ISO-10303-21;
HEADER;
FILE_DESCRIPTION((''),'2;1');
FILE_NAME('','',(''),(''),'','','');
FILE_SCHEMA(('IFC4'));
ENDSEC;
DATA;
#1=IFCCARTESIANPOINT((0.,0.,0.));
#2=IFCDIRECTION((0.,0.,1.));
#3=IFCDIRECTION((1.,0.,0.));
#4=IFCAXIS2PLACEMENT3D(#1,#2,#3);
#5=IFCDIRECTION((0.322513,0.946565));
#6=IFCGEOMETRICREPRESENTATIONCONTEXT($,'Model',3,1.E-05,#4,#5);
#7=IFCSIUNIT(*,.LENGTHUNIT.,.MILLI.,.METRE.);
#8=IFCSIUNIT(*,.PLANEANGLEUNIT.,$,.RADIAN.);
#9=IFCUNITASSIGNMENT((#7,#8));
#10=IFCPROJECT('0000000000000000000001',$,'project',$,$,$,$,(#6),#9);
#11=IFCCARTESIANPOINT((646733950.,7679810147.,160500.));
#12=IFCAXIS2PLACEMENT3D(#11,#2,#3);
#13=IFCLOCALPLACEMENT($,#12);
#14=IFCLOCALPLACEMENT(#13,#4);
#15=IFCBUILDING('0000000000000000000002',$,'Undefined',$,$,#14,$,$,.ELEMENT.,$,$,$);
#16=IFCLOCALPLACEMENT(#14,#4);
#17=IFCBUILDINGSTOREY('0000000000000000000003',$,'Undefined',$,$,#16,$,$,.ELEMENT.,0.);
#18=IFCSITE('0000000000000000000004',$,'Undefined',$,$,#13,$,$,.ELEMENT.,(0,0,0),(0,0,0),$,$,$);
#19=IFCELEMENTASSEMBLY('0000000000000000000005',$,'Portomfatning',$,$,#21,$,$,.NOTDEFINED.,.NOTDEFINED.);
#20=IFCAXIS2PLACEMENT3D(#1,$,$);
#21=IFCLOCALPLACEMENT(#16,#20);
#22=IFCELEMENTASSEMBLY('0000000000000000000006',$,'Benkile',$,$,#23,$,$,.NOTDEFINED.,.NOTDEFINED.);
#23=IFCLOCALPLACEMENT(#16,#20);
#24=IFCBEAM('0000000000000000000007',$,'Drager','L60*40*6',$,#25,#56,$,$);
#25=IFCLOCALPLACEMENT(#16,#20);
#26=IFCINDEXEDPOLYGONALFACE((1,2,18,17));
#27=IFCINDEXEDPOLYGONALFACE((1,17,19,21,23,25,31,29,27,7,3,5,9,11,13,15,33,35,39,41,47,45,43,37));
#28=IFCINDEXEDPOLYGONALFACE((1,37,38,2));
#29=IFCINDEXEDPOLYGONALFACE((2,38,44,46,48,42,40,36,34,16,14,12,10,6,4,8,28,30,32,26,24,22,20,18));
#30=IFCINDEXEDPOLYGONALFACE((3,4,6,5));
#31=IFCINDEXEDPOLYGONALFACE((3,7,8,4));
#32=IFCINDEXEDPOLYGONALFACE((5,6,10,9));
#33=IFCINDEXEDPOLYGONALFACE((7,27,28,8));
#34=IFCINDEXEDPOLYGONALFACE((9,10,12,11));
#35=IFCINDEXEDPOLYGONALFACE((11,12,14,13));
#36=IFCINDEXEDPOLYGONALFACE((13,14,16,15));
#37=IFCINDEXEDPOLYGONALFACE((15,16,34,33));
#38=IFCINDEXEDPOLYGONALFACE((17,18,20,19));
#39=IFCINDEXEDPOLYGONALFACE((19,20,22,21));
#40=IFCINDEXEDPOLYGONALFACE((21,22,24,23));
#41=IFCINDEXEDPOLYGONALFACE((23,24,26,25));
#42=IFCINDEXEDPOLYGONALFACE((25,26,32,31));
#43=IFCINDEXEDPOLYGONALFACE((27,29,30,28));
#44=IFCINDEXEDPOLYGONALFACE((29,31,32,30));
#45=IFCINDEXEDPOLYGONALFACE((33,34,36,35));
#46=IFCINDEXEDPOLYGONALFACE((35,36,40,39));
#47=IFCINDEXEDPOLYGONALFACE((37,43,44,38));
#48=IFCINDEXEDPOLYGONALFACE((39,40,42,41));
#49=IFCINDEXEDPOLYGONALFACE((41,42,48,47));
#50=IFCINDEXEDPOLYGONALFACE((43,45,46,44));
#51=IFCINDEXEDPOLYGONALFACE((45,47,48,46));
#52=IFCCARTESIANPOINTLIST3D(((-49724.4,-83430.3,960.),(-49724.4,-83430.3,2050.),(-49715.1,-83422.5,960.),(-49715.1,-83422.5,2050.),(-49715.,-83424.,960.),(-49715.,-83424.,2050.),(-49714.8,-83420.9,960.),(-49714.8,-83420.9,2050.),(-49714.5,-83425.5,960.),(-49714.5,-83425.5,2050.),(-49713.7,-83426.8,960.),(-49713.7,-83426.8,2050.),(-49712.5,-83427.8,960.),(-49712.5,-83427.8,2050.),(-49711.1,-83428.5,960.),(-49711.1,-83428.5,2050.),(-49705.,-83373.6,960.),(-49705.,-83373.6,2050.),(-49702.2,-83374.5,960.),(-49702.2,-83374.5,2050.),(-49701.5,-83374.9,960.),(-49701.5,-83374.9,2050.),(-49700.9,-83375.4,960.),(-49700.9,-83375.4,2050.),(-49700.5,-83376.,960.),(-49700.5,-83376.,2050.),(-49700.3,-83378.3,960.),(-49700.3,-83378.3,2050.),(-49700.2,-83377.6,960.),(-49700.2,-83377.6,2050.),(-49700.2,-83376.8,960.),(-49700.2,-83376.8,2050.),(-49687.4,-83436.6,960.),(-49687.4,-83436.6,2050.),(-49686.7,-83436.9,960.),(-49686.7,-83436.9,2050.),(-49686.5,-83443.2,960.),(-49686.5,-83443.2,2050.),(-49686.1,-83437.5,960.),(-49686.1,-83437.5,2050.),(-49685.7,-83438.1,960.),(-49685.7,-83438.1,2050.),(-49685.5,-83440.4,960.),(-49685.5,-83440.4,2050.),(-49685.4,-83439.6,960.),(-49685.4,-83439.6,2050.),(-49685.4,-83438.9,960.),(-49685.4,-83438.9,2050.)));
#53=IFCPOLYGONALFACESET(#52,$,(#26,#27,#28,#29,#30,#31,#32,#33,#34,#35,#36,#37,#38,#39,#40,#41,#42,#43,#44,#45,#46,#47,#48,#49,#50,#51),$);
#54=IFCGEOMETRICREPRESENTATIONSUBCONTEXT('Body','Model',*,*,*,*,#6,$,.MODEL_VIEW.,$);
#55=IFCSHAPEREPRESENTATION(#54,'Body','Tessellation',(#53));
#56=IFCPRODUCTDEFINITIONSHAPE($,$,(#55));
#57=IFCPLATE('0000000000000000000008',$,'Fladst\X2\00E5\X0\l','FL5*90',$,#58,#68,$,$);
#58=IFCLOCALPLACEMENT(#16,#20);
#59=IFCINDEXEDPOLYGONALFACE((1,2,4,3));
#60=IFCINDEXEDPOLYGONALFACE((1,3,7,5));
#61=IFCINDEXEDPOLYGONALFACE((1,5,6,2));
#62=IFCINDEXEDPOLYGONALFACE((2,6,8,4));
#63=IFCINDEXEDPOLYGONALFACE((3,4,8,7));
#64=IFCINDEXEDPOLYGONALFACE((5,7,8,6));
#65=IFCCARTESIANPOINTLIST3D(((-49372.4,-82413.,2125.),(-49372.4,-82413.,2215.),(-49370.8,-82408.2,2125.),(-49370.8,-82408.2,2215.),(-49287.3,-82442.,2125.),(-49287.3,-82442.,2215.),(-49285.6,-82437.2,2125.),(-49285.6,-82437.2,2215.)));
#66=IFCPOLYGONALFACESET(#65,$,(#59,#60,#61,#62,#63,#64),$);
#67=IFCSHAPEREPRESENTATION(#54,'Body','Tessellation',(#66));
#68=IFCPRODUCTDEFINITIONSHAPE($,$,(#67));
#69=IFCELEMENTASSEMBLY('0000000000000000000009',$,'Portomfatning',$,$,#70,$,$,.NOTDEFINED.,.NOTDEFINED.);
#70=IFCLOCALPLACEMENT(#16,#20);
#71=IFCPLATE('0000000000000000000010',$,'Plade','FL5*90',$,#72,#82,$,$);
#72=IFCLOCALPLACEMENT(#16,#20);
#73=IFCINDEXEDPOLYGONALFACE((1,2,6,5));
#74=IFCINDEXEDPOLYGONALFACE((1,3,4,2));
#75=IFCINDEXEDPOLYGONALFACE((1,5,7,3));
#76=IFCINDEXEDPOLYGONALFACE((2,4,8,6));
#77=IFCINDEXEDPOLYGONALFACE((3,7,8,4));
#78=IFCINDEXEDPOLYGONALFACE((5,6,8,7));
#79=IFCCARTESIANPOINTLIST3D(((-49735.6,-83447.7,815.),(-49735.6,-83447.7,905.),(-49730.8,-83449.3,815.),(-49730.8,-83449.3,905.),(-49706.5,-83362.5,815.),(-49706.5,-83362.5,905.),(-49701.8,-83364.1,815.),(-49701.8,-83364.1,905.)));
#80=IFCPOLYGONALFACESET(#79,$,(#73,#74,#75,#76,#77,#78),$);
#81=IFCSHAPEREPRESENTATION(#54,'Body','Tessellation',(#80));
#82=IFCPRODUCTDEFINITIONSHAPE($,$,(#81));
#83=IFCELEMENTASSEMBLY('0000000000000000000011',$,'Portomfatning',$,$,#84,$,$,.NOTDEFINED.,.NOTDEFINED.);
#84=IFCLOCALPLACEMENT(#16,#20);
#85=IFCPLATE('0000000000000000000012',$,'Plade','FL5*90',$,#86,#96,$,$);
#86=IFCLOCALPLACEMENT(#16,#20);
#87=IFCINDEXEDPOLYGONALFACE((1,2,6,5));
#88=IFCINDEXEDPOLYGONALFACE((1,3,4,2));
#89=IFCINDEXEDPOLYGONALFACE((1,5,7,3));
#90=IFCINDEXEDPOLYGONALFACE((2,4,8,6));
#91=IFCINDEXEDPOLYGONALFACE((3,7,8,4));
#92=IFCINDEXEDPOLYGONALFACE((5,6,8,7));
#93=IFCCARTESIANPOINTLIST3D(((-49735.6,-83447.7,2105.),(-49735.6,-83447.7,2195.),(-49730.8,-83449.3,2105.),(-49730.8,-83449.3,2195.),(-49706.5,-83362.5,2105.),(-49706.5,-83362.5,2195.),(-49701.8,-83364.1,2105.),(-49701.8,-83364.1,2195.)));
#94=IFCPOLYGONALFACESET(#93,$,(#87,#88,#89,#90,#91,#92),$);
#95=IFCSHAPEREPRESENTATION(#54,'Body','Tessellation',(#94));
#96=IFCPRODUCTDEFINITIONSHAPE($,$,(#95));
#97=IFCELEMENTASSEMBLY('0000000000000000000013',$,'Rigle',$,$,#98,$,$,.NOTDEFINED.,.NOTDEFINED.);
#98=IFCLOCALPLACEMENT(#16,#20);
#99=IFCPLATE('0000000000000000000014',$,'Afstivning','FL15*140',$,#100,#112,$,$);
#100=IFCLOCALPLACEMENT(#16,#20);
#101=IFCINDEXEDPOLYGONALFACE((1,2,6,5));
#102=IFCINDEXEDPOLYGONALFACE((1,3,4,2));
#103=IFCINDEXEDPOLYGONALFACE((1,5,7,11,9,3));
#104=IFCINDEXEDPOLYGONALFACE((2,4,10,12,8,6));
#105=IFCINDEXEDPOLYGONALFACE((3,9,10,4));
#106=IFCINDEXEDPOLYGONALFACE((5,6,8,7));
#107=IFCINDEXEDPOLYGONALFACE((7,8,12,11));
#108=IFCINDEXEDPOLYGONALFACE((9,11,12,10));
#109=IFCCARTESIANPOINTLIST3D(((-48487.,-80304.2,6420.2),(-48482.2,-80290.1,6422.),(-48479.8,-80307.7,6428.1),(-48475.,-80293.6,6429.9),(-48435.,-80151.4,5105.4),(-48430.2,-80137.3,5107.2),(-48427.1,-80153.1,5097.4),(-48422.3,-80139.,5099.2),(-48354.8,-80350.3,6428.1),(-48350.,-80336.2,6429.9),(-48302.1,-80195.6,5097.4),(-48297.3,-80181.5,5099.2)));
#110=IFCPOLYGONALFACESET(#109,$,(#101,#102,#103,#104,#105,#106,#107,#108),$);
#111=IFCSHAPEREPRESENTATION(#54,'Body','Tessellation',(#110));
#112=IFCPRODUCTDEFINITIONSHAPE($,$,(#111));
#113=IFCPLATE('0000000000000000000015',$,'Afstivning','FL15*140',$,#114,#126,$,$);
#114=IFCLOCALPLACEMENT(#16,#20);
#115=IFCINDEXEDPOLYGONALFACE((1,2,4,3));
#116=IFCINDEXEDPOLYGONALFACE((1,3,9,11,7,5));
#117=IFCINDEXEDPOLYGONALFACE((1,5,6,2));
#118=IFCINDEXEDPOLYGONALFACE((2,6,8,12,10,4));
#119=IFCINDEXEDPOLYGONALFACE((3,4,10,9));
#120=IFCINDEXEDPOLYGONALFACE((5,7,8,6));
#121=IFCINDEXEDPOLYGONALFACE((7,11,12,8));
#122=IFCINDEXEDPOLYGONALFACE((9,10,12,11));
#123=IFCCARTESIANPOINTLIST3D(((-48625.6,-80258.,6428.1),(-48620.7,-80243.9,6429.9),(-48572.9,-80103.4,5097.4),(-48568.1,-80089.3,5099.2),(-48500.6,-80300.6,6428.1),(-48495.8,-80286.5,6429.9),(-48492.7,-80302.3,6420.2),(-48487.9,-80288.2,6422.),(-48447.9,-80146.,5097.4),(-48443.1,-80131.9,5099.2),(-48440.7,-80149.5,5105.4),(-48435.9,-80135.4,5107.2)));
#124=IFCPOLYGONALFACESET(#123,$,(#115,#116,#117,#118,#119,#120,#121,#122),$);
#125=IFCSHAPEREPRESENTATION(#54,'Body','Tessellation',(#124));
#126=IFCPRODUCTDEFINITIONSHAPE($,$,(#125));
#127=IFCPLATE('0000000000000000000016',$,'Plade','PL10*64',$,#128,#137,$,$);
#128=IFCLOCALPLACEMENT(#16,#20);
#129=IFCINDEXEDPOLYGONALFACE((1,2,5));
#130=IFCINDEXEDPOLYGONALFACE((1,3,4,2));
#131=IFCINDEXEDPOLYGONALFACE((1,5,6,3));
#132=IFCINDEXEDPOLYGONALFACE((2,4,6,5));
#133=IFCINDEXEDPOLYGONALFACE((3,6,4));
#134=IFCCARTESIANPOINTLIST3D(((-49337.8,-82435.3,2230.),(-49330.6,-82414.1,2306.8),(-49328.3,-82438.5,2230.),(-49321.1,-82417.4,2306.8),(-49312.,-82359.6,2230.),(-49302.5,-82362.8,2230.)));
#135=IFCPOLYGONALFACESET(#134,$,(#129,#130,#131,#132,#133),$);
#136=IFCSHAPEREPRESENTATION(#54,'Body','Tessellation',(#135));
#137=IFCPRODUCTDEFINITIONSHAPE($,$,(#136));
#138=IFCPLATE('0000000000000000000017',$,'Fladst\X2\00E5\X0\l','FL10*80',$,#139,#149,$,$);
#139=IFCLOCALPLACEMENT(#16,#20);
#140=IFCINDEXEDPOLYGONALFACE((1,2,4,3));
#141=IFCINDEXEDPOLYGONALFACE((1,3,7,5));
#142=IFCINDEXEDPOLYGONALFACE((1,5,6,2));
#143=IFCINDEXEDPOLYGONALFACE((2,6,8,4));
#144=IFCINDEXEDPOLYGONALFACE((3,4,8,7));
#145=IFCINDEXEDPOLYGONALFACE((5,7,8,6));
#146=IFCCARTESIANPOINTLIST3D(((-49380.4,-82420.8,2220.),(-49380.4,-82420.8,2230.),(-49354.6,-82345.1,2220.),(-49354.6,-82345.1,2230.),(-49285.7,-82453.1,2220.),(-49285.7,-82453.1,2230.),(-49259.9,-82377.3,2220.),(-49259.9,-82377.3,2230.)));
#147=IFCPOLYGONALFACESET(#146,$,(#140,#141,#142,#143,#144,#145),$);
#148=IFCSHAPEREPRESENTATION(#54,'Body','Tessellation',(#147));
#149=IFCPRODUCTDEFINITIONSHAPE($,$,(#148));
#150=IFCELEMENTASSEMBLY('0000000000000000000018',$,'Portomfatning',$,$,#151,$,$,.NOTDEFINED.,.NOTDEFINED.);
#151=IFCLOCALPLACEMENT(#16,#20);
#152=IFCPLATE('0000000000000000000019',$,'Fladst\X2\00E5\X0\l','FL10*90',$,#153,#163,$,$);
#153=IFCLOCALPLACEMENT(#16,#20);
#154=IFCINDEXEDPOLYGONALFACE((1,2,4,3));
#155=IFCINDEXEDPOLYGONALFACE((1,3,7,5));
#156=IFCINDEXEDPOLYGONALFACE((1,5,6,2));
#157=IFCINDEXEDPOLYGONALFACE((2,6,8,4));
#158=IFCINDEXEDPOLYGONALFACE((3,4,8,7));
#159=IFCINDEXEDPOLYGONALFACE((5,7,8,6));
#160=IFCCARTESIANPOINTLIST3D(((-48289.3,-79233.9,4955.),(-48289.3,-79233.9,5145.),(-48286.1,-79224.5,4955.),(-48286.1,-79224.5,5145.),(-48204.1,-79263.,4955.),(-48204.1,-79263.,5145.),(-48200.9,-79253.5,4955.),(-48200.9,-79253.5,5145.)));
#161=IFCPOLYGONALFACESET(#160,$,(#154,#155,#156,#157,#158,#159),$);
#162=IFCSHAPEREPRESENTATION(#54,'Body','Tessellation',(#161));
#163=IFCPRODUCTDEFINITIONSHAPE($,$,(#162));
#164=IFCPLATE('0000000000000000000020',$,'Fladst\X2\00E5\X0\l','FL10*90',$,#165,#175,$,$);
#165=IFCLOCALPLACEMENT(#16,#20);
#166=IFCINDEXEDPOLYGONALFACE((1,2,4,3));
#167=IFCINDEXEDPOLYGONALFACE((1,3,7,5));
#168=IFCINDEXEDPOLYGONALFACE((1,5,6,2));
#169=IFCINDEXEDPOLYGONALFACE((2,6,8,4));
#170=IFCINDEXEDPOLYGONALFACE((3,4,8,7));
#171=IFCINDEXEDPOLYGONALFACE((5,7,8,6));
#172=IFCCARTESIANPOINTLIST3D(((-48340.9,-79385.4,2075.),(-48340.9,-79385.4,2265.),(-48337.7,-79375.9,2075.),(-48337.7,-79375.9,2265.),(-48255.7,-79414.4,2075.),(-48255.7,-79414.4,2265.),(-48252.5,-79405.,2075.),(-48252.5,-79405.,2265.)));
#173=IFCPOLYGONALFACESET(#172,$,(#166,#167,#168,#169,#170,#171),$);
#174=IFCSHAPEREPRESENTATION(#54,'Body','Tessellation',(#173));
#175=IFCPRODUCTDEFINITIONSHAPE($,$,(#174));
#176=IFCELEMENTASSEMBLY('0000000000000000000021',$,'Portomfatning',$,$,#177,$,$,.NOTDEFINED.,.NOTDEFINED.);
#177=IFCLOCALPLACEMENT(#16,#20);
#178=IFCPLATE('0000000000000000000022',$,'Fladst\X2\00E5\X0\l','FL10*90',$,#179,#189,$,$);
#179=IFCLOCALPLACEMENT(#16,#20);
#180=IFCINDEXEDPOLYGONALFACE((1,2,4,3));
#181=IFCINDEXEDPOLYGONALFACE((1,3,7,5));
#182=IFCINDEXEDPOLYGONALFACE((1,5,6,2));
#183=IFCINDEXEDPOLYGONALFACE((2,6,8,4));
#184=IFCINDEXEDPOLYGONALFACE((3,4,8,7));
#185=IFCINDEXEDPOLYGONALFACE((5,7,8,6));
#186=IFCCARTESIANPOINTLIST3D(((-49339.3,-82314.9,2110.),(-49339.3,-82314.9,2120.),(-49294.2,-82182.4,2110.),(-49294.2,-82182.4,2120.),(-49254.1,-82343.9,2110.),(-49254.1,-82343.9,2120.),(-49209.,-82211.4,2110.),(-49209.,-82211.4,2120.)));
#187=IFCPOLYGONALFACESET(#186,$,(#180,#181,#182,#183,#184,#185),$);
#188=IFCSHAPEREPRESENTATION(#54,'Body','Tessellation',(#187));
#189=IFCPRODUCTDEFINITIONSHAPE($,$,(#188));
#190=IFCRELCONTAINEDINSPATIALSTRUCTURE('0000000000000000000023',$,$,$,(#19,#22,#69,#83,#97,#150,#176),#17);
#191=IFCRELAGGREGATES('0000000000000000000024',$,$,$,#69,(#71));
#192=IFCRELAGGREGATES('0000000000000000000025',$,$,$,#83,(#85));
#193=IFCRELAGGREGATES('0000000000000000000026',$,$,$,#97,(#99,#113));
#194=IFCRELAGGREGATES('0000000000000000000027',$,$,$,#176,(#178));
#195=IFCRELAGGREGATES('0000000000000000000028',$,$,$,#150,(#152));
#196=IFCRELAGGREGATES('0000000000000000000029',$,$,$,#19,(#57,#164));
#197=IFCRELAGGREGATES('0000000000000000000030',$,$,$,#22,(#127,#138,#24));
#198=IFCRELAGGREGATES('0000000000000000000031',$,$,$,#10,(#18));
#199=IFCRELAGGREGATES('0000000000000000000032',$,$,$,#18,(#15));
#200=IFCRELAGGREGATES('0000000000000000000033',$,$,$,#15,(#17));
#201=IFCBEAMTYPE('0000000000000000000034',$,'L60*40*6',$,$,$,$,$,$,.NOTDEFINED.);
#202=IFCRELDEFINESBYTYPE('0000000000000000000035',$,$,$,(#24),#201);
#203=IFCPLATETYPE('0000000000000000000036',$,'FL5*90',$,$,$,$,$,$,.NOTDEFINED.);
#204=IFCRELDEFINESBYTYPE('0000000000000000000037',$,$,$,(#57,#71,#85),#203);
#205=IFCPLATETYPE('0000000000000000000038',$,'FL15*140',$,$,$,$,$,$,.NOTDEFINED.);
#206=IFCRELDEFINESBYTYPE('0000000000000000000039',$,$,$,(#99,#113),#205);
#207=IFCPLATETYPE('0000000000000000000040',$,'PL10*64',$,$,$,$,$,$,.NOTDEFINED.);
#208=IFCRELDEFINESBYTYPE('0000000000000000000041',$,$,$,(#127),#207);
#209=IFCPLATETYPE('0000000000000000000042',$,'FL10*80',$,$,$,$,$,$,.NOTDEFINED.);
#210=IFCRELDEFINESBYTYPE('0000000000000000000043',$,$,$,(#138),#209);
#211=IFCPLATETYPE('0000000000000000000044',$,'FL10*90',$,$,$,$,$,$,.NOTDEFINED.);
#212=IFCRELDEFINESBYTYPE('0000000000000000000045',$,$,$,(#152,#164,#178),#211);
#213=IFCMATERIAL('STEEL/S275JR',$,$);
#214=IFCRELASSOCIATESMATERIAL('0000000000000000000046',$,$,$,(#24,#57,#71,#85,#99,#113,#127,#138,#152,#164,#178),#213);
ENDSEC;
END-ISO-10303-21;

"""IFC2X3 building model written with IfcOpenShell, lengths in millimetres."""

from ifc_helpers import new_model, si_unit, direction, frame, origin_with_axes, origin_2d_with_axis, place, context, subcontext, project, spatial, polyline, l_section, outline, extrude, material, type_object, element, aggregate, save


model = new_model("IFC2X3")

# Units and contexts
model_context = context("Model", 3, precision=1e-05, world=origin_with_axes(), true_north=direction((0.322513, 0.946565)))
body_context = subcontext(model_context, "Body", "Model", "MODEL_VIEW")
ifc_project = project(units=[si_unit("LENGTHUNIT", "METRE", prefix="MILLI"), si_unit("PLANEANGLEUNIT", "RADIAN")], contexts=[model_context])

# Site, building, storey
site_placement = place(None, frame((646733950.0, 7679810147.0, 160500.0), z_axis=(0.0, 0.0, 1.0), x_axis=(1.0, 0.0, 0.0)))
site = spatial("IfcSite", under=ifc_project, at=site_placement, Name="Undefined", CompositionType="ELEMENT", RefLatitude=(0, 0, 0), RefLongitude=(0, 0, 0))
building_placement = place(site_placement, origin_with_axes())
building = spatial("IfcBuilding", under=site, at=building_placement, Name="Undefined", CompositionType="ELEMENT")
storey_placement = place(building_placement, origin_with_axes())
storey = spatial("IfcBuildingStorey", under=building, at=storey_placement, Name="Undefined", CompositionType="ELEMENT", Elevation=0.0)

# Element assemblies, beam
assembly_1_placement = place(storey_placement, origin_with_axes())
assembly_1 = element("IfcElementAssembly", 1, at=assembly_1_placement, inside=storey, Name="Portomfatning", AssemblyPlace="NOTDEFINED", PredefinedType="NOTDEFINED")
assembly_2_placement = place(storey_placement, origin_with_axes())
assembly_2 = element("IfcElementAssembly", 2, at=assembly_2_placement, inside=storey, Name="Benkile", AssemblyPlace="NOTDEFINED", PredefinedType="NOTDEFINED")
ifc_material_1 = material(Name="STEEL/S275JR")
beam_type_1 = type_object("IfcBeamType", Name="L60*40*6", PredefinedType="NOTDEFINED")
beam_1_placement = place(assembly_2_placement, frame((-49695.8, -83408.4, 2050.0), z_axis=(0.322513, 0.946565, 0.0), x_axis=(0.0, 0.0, -1.0)))
beam_1 = element("IfcBeam", 3, at=beam_1_placement, type_object=beam_type_1, material=ifc_material_1, Name="Drager", Description="L60*40*6", context=body_context, shape_type="SweptSolid", body=[
    extrude(l_section(Depth=60.0, Width=40.0, Thickness=6.0, FilletRadius=6.0, EdgeRadius=3.0, at=origin_2d_with_axis()), frame((1090.0, 0.0, 0.0), z_axis=(-1.0, 0.0, 0.0), x_axis=(0.0, -1.0, 0.0)), (0.0, 0.0, 1.0), 1090.0),
])

# Plate
plate_type_1 = type_object("IfcPlateType", Name="FL5*90", PredefinedType="NOTDEFINED")
plate_1_placement = place(assembly_1_placement, frame((-49371.6, -82410.6, 2170.0), z_axis=(0.322513, 0.946565, 0.0), x_axis=(0.946565, -0.322513, 0.0)))
plate_1 = element("IfcPlate", 4, at=plate_1_placement, type_object=plate_type_1, material=ifc_material_1, Name="Fladstål", Description="FL5*90", context=body_context, shape_type="SweptSolid", body=[
    extrude(outline(polyline([(0.0, -45.0), (0.0, 45.0), (90.0, 45.0), (90.0, -45.0), (0.0, -45.0)])), frame((0.0, 0.0, -2.5), z_axis=(0.0, 0.0, 1.0), x_axis=(1.0, 0.0, 0.0)), (0.0, 0.0, 1.0), 5.0),
])

# Element assemblies, plates
assembly_3_placement = place(storey_placement, origin_with_axes())
assembly_3 = element("IfcElementAssembly", 5, at=assembly_3_placement, inside=storey, Name="Portomfatning", AssemblyPlace="NOTDEFINED", PredefinedType="NOTDEFINED")
plate_2_placement = place(assembly_3_placement, frame((-49704.1, -83363.3, 815.0), z_axis=(0.946505, -0.322688, 0.0), x_axis=(0.0, 0.0, 1.0)))
plate_2 = element("IfcPlate", 6, at=plate_2_placement, type_object=plate_type_1, material=ifc_material_1, Name="Plade", Description="FL5*90", context=body_context, shape_type="SweptSolid", body=[
    extrude(outline(polyline([(0.0, 0.0), (90.0, 0.0), (90.0, 90.0), (0.0, 90.0), (0.0, 0.0)])), frame((0.0, 0.0, -2.5), z_axis=(0.0, 0.0, 1.0), x_axis=(1.0, 0.0, 0.0)), (0.0, 0.0, 1.0), 5.0),
])
aggregate(assembly_3, [plate_2])
assembly_4_placement = place(storey_placement, origin_with_axes())
assembly_4 = element("IfcElementAssembly", 7, at=assembly_4_placement, inside=storey, Name="Portomfatning", AssemblyPlace="NOTDEFINED", PredefinedType="NOTDEFINED")
plate_3_placement = place(assembly_4_placement, frame((-49704.1, -83363.3, 2105.0), z_axis=(0.946505, -0.322688, 0.0), x_axis=(0.0, 0.0, 1.0)))
plate_3 = element("IfcPlate", 8, at=plate_3_placement, type_object=plate_type_1, material=ifc_material_1, Name="Plade", Description="FL5*90", context=body_context, shape_type="SweptSolid", body=[
    extrude(outline(polyline([(0.0, 0.0), (90.0, 0.0), (90.0, 90.0), (0.0, 90.0), (0.0, 0.0)])), frame((0.0, 0.0, -2.5), z_axis=(0.0, 0.0, 1.0), x_axis=(1.0, 0.0, 0.0)), (0.0, 0.0, 1.0), 5.0),
])
aggregate(assembly_4, [plate_3])

# Element assembly, plates
assembly_5_placement = place(storey_placement, origin_with_axes())
assembly_5 = element("IfcElementAssembly", 9, at=assembly_5_placement, inside=storey, Name="Rigle", AssemblyPlace="NOTDEFINED", PredefinedType="NOTDEFINED")
plate_type_2 = type_object("IfcPlateType", Name="FL15*140", PredefinedType="NOTDEFINED")
plate_4_placement = place(assembly_5_placement, frame((-48299.7, -80188.6, 5098.3), z_axis=(0.320109, 0.93951, 0.121869), x_axis=(-0.946565, 0.322513, 0.0)))
plate_4 = element("IfcPlate", 10, at=plate_4_placement, type_object=plate_type_2, material=ifc_material_1, Name="Afstivning", Description="FL15*140", context=body_context, shape_type="SweptSolid", body=[
    extrude(outline(polyline([(0.0, 0.0), (132.0, 0.0), (140.0, 8.0), (140.0, 1332.7), (132.0, 1340.7), (0.0, 1340.7), (0.0, 0.0)])), frame((0.0, 0.0, -7.5), z_axis=(0.0, 0.0, 1.0), x_axis=(1.0, 0.0, 0.0)), (0.0, 0.0, 1.0), 15.0),
])
plate_5_placement = place(assembly_5_placement, frame((-48437.9, -80141.5, 5098.3), z_axis=(0.320109, 0.93951, 0.121869), x_axis=(-0.946565, 0.322513, 0.0)))
plate_5 = element("IfcPlate", 11, at=plate_5_placement, type_object=plate_type_2, material=ifc_material_1, Name="Afstivning", Description="FL15*140", context=body_context, shape_type="SweptSolid", body=[
    extrude(outline(polyline([(0.0, 8.0), (8.0, 0.0), (140.0, 0.0), (140.0, 1340.7), (8.0, 1340.7), (0.0, 1332.7), (0.0, 8.0)])), frame((0.0, 0.0, -7.5), z_axis=(0.0, 0.0, 1.0), x_axis=(1.0, 0.0, 0.0)), (0.0, 0.0, 1.0), 15.0),
])

# Plates
plate_type_3 = type_object("IfcPlateType", Name="PL10*64", PredefinedType="NOTDEFINED")
plate_6_placement = place(assembly_2_placement, frame((-49333.1, -82436.9, 2230.0), z_axis=(0.946565, -0.322513, 0.0), x_axis=(0.322513, 0.946565, 0.0)))
plate_6 = element("IfcPlate", 12, at=plate_6_placement, type_object=plate_type_3, material=ifc_material_1, Name="Plade", Description="PL10*64", context=body_context, shape_type="SweptSolid", body=[
    extrude(outline(polyline([(0.0, 0.0), (80.0, 0.0), (22.4, 76.8), (0.0, 0.0)])), frame((0.0, 0.0, -5.0), z_axis=(0.0, 0.0, 1.0), x_axis=(1.0, 0.0, 0.0)), (0.0, 0.0, 1.0), 10.0),
])
plate_type_4 = type_object("IfcPlateType", Name="FL10*80", PredefinedType="NOTDEFINED")
plate_7_placement = place(assembly_2_placement, frame((-49333.1, -82436.9, 2225.0), z_axis=(0.0, 0.0, 1.0), x_axis=(0.322513, 0.946565, 0.0)))
plate_7 = element("IfcPlate", 13, at=plate_7_placement, type_object=plate_type_4, material=ifc_material_1, Name="Fladstål", Description="FL10*80", context=body_context, shape_type="SweptSolid", body=[
    extrude(outline(polyline([(0.0, -50.0), (0.0, 50.0), (80.0, 50.0), (80.0, -50.0), (0.0, -50.0)])), frame((0.0, 0.0, -5.0), z_axis=(0.0, 0.0, 1.0), x_axis=(1.0, 0.0, 0.0)), (0.0, 0.0, 1.0), 10.0),
])

# Element assembly, plate
assembly_6_placement = place(storey_placement, origin_with_axes())
assembly_6 = element("IfcElementAssembly", 14, at=assembly_6_placement, inside=storey, Name="Portomfatning", AssemblyPlace="NOTDEFINED", PredefinedType="NOTDEFINED")
plate_type_5 = type_object("IfcPlateType", Name="FL10*90", PredefinedType="NOTDEFINED")
plate_8_placement = place(assembly_6_placement, frame((-48245.1, -79243.7, 4955.0), z_axis=(0.322513, 0.946565, 0.0), x_axis=(0.0, 0.0, 1.0)))
plate_8 = element("IfcPlate", 15, at=plate_8_placement, type_object=plate_type_5, material=ifc_material_1, Name="Fladstål", Description="FL10*90", context=body_context, shape_type="SweptSolid", body=[
    extrude(outline(polyline([(0.0, -45.0), (0.0, 45.0), (190.0, 45.0), (190.0, -45.0), (0.0, -45.0)])), frame((0.0, 0.0, -5.0), z_axis=(0.0, 0.0, 1.0), x_axis=(1.0, 0.0, 0.0)), (0.0, 0.0, 1.0), 10.0),
])

# Plate
plate_9_placement = place(assembly_1_placement, frame((-48296.7, -79395.2, 2075.0), z_axis=(-0.322513, -0.946565, 0.0), x_axis=(0.0, 0.0, 1.0)))
plate_9 = element("IfcPlate", 16, at=plate_9_placement, type_object=plate_type_5, material=ifc_material_1, Name="Fladstål", Description="FL10*90", context=body_context, shape_type="SweptSolid", body=[
    extrude(outline(polyline([(0.0, -45.0), (0.0, 45.0), (190.0, 45.0), (190.0, -45.0), (0.0, -45.0)])), frame((0.0, 0.0, -5.0), z_axis=(0.0, 0.0, 1.0), x_axis=(1.0, 0.0, 0.0)), (0.0, 0.0, 1.0), 10.0),
])

# Element assembly, plate
assembly_7_placement = place(storey_placement, origin_with_axes())
assembly_7 = element("IfcElementAssembly", 17, at=assembly_7_placement, inside=storey, Name="Portomfatning", AssemblyPlace="NOTDEFINED", PredefinedType="NOTDEFINED")
plate_10_placement = place(assembly_7_placement, frame((-49251.6, -82196.9, 2115.0), z_axis=(0.0, 0.0, -1.0), x_axis=(-0.322513, -0.946565, 0.0)))
plate_10 = element("IfcPlate", 18, at=plate_10_placement, type_object=plate_type_5, material=ifc_material_1, Name="Fladstål", Description="FL10*90", context=body_context, shape_type="SweptSolid", body=[
    extrude(outline(polyline([(0.0, -45.0), (0.0, 45.0), (140.0, 45.0), (140.0, -45.0), (0.0, -45.0)])), frame((0.0, 0.0, -5.0), z_axis=(0.0, 0.0, 1.0), x_axis=(1.0, 0.0, 0.0)), (0.0, 0.0, 1.0), 10.0),
])

aggregate(assembly_5, [plate_4, plate_5])

aggregate(assembly_7, [plate_10])
aggregate(assembly_6, [plate_8])
aggregate(assembly_1, [plate_1, plate_9])
aggregate(assembly_2, [plate_6, plate_7, beam_1])

save(model, "model.ifc")
